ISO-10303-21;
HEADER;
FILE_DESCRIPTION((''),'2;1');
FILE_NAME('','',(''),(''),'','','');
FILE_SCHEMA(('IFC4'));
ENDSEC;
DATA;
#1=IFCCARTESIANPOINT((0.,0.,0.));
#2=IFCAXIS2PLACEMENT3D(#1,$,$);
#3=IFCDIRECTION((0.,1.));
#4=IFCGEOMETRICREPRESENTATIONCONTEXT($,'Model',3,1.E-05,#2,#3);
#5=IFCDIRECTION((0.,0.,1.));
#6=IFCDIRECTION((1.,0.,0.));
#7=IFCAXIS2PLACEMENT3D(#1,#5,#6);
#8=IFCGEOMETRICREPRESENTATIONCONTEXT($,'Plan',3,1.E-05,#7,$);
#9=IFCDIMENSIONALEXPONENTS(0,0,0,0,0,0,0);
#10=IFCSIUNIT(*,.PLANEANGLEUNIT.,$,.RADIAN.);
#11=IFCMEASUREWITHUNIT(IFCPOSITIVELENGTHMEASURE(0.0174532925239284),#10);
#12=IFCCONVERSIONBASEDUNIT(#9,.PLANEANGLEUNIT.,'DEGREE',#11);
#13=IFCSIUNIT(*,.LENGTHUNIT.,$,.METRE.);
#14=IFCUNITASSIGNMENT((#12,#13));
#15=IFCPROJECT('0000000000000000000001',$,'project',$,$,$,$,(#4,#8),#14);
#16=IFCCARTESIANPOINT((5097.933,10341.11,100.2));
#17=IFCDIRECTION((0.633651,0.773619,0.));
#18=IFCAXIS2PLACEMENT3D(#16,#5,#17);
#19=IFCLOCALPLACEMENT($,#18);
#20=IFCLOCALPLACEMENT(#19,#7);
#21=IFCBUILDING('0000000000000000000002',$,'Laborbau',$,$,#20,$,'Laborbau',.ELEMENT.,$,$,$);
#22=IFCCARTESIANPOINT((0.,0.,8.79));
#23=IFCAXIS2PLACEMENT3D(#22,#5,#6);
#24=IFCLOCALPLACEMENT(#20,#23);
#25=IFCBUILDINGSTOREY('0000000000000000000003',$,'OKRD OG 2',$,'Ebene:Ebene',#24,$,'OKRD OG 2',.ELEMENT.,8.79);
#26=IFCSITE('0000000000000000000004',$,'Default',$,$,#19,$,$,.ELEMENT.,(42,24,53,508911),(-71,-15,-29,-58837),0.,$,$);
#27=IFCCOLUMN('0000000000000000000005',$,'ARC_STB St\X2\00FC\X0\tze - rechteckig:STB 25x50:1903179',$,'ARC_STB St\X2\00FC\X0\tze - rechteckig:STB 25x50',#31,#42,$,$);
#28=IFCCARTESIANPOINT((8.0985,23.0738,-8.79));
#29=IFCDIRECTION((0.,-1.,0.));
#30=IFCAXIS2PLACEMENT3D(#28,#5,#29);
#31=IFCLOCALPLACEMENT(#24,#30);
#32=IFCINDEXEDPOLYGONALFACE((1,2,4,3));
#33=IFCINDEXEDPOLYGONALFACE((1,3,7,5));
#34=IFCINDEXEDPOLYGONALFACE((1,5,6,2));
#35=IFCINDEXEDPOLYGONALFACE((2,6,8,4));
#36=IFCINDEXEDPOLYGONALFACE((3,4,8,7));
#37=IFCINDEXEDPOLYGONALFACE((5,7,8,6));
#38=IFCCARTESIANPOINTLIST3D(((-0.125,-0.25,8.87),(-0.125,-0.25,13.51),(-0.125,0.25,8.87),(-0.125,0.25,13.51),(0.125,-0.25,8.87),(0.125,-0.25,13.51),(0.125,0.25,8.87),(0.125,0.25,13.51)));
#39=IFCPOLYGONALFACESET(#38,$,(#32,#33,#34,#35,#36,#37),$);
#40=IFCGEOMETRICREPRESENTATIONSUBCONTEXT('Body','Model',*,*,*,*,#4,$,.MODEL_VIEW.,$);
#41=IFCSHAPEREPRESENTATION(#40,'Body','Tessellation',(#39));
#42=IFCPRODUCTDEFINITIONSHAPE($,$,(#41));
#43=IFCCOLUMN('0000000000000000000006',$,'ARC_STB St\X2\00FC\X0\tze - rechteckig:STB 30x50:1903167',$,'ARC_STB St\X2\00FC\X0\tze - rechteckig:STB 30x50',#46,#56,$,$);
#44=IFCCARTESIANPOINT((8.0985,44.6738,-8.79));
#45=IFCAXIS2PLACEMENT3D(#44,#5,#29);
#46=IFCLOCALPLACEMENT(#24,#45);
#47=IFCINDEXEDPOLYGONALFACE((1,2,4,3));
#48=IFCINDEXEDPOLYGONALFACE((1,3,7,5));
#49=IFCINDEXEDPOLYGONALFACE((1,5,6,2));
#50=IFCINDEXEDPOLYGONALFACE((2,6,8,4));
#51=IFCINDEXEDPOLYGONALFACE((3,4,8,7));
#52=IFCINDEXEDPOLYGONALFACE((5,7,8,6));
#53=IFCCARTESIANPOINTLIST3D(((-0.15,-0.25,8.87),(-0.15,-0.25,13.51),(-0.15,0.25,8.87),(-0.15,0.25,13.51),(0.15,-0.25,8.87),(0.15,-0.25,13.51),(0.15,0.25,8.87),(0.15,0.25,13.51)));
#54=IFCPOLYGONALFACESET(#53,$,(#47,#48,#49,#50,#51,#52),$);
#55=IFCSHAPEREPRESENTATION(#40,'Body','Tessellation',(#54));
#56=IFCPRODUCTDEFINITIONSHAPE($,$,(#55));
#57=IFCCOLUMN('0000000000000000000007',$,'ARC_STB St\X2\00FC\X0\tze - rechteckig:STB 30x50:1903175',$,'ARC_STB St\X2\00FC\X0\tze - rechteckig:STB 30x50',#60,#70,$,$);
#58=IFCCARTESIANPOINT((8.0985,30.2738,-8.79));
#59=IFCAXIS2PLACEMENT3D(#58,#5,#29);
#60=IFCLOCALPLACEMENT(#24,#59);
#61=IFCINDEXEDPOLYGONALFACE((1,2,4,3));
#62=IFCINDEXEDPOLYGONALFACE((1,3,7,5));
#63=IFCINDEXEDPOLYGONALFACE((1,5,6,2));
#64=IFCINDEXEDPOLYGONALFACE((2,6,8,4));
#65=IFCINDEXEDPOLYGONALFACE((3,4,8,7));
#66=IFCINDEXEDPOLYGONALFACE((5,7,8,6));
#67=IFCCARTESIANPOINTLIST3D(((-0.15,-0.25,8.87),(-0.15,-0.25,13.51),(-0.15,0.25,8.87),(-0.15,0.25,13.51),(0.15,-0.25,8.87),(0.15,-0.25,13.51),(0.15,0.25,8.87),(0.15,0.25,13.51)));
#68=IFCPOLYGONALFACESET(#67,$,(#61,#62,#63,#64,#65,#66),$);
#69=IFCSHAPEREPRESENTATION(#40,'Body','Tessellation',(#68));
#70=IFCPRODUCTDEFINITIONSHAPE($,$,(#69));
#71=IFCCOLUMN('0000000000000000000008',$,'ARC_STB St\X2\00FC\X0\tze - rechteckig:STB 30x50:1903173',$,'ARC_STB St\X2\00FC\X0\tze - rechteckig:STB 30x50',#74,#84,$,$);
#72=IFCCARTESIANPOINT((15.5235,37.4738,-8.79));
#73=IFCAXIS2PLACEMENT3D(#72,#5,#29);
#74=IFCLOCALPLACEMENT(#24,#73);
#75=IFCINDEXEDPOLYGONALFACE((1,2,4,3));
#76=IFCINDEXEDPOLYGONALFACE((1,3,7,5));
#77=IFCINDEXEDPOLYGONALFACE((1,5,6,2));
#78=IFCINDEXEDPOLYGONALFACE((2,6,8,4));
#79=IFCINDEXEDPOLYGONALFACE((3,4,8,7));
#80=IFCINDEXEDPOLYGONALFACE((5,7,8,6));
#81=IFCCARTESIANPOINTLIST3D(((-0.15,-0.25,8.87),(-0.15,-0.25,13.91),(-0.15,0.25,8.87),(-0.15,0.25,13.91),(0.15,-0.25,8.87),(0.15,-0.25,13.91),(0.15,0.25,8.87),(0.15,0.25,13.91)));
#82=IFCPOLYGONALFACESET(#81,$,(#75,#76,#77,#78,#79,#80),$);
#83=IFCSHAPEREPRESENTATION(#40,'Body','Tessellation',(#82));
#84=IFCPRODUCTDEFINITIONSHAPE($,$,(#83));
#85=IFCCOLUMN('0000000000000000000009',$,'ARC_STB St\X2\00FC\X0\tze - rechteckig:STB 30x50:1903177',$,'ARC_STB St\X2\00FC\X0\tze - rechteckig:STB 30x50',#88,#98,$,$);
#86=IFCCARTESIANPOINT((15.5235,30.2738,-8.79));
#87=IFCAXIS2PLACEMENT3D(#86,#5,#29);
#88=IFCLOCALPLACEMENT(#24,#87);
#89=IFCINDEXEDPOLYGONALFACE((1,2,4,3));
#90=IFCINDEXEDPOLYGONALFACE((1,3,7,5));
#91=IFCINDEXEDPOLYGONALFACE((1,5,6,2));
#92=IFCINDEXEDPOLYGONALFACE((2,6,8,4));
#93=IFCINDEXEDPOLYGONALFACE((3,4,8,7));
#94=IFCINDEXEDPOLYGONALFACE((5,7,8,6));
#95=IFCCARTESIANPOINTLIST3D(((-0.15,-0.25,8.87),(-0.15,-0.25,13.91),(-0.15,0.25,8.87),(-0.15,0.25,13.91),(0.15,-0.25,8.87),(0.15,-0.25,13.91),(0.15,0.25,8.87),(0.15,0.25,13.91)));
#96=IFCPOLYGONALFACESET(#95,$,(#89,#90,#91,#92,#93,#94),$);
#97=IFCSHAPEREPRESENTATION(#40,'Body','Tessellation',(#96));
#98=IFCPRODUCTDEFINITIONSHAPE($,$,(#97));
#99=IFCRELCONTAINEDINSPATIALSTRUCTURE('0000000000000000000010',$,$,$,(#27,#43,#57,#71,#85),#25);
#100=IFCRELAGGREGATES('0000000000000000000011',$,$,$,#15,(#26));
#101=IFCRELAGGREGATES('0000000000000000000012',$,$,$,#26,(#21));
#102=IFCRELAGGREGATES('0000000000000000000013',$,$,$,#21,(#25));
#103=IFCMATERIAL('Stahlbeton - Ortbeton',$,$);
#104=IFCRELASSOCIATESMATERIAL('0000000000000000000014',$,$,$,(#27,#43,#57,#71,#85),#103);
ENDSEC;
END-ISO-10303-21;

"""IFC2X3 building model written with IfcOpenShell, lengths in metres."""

from ifc_helpers import new_model, entity, si_unit, converted_unit, direction, frame, origin, origin_with_axes, origin_2d_with_axis, place, context, subcontext, project, spatial, rectangle, extrude, source, transform, mapped, material, element, save


model = new_model("IFC2X3")

# Units and contexts
model_context = context("Model", 3, precision=1e-05, world=origin(), true_north=direction((0.0, 1.0)))
plan_context = context("Plan", 3, precision=1e-05, world=origin_with_axes())
body_context = subcontext(model_context, "Body", "Model", "MODEL_VIEW")
ifc_project = project(units=[converted_unit("PLANEANGLEUNIT", "DEGREE", entity("IfcPositiveLengthMeasure", 0.0174532925239284), si_unit("PLANEANGLEUNIT", "RADIAN"), dimensions=[0, 0, 0, 0, 0, 0, 0]), si_unit("LENGTHUNIT", "METRE")], contexts=[model_context, plan_context])

# Site, building, storey
site_placement = place(None, frame((5097.933, 10341.11, 100.2), z_axis=(0.0, 0.0, 1.0), x_axis=(0.633651, 0.773619, 0.0)))
site = spatial("IfcSite", under=ifc_project, at=site_placement, Name="Default", CompositionType="ELEMENT", RefLatitude=(42, 24, 53, 508911), RefLongitude=(-71, -15, -29, -58837), RefElevation=0.0)
building_placement = place(site_placement, origin_with_axes())
building = spatial("IfcBuilding", under=site, at=building_placement, Name="Laborbau", LongName="Laborbau", CompositionType="ELEMENT")
storey_placement = place(building_placement, frame((0.0, 0.0, 8.79), z_axis=(0.0, 0.0, 1.0), x_axis=(1.0, 0.0, 0.0)))
storey = spatial("IfcBuildingStorey", under=building, at=storey_placement, Name="OKRD OG 2", ObjectType="Ebene:Ebene", LongName="OKRD OG 2", CompositionType="ELEMENT", Elevation=8.79)

# Columns
ifc_material_1 = material(Name="Stahlbeton - Ortbeton")
shared_shape_1 = source(origin(), body_context, "Body", "SweptSolid", [
    extrude(rectangle(XDim=0.5, YDim=0.25, at=origin_2d_with_axis()), frame((0.0, 0.0, 8.87), z_axis=(0.0, 0.0, 1.0), x_axis=(0.0, -1.0, 0.0)), (0.0, 0.0, 1.0), 4.64),
])
column_placement = place(storey_placement, frame((8.0985, 23.0738, -8.79), z_axis=(0.0, 0.0, 1.0), x_axis=(0.0, -1.0, 0.0)))
element("IfcColumn", 1, at=column_placement, inside=storey, material=ifc_material_1, Name="ARC_STB Stütze - rechteckig:STB 25x50:1903179", ObjectType="ARC_STB Stütze - rechteckig:STB 25x50", context=body_context, shape_type="MappedRepresentation", body=[
    mapped(shared_shape_1, transform((0.0, 0.0, 0.0), scale=1.0)),
])
shared_shape_2 = source(origin(), body_context, "Body", "SweptSolid", [
    extrude(rectangle(XDim=0.5, YDim=0.3, at=origin_2d_with_axis()), frame((0.0, 0.0, 8.87), z_axis=(0.0, 0.0, 1.0), x_axis=(0.0, -1.0, 0.0)), (0.0, 0.0, 1.0), 4.64),
])
for number, where, z_axis, x_axis, name in (
    (2, (8.0985, 44.6738, -8.79), (0.0, 0.0, 1.0), (0.0, -1.0, 0.0), "ARC_STB Stütze - rechteckig:STB 30x50:1903167"),
    (3, (8.0985, 30.2738, -8.79), (0.0, 0.0, 1.0), (0.0, -1.0, 0.0), "ARC_STB Stütze - rechteckig:STB 30x50:1903175"),
):
    element("IfcColumn", number, at=place(storey_placement, frame(where, z_axis=z_axis, x_axis=x_axis)), inside=storey, material=ifc_material_1, Name=name, ObjectType="ARC_STB Stütze - rechteckig:STB 30x50", context=body_context, shape_type="MappedRepresentation", body=[
        mapped(shared_shape_2, transform((0.0, 0.0, 0.0), scale=1.0)),
    ])
shared_shape_3 = source(origin(), body_context, "Body", "SweptSolid", [
    extrude(rectangle(XDim=0.5, YDim=0.3, at=origin_2d_with_axis()), frame((0.0, 0.0, 8.87), z_axis=(0.0, 0.0, 1.0), x_axis=(0.0, -1.0, 0.0)), (0.0, 0.0, 1.0), 5.04),
])
for number, where, z_axis, x_axis, name in (
    (4, (15.5235, 37.4738, -8.79), (0.0, 0.0, 1.0), (0.0, -1.0, 0.0), "ARC_STB Stütze - rechteckig:STB 30x50:1903173"),
    (5, (15.5235, 30.2738, -8.79), (0.0, 0.0, 1.0), (0.0, -1.0, 0.0), "ARC_STB Stütze - rechteckig:STB 30x50:1903177"),
):
    element("IfcColumn", number, at=place(storey_placement, frame(where, z_axis=z_axis, x_axis=x_axis)), inside=storey, material=ifc_material_1, Name=name, ObjectType="ARC_STB Stütze - rechteckig:STB 30x50", context=body_context, shape_type="MappedRepresentation", body=[
        mapped(shared_shape_3, transform((0.0, 0.0, 0.0), scale=1.0)),
    ])

save(model, "model.ifc")
